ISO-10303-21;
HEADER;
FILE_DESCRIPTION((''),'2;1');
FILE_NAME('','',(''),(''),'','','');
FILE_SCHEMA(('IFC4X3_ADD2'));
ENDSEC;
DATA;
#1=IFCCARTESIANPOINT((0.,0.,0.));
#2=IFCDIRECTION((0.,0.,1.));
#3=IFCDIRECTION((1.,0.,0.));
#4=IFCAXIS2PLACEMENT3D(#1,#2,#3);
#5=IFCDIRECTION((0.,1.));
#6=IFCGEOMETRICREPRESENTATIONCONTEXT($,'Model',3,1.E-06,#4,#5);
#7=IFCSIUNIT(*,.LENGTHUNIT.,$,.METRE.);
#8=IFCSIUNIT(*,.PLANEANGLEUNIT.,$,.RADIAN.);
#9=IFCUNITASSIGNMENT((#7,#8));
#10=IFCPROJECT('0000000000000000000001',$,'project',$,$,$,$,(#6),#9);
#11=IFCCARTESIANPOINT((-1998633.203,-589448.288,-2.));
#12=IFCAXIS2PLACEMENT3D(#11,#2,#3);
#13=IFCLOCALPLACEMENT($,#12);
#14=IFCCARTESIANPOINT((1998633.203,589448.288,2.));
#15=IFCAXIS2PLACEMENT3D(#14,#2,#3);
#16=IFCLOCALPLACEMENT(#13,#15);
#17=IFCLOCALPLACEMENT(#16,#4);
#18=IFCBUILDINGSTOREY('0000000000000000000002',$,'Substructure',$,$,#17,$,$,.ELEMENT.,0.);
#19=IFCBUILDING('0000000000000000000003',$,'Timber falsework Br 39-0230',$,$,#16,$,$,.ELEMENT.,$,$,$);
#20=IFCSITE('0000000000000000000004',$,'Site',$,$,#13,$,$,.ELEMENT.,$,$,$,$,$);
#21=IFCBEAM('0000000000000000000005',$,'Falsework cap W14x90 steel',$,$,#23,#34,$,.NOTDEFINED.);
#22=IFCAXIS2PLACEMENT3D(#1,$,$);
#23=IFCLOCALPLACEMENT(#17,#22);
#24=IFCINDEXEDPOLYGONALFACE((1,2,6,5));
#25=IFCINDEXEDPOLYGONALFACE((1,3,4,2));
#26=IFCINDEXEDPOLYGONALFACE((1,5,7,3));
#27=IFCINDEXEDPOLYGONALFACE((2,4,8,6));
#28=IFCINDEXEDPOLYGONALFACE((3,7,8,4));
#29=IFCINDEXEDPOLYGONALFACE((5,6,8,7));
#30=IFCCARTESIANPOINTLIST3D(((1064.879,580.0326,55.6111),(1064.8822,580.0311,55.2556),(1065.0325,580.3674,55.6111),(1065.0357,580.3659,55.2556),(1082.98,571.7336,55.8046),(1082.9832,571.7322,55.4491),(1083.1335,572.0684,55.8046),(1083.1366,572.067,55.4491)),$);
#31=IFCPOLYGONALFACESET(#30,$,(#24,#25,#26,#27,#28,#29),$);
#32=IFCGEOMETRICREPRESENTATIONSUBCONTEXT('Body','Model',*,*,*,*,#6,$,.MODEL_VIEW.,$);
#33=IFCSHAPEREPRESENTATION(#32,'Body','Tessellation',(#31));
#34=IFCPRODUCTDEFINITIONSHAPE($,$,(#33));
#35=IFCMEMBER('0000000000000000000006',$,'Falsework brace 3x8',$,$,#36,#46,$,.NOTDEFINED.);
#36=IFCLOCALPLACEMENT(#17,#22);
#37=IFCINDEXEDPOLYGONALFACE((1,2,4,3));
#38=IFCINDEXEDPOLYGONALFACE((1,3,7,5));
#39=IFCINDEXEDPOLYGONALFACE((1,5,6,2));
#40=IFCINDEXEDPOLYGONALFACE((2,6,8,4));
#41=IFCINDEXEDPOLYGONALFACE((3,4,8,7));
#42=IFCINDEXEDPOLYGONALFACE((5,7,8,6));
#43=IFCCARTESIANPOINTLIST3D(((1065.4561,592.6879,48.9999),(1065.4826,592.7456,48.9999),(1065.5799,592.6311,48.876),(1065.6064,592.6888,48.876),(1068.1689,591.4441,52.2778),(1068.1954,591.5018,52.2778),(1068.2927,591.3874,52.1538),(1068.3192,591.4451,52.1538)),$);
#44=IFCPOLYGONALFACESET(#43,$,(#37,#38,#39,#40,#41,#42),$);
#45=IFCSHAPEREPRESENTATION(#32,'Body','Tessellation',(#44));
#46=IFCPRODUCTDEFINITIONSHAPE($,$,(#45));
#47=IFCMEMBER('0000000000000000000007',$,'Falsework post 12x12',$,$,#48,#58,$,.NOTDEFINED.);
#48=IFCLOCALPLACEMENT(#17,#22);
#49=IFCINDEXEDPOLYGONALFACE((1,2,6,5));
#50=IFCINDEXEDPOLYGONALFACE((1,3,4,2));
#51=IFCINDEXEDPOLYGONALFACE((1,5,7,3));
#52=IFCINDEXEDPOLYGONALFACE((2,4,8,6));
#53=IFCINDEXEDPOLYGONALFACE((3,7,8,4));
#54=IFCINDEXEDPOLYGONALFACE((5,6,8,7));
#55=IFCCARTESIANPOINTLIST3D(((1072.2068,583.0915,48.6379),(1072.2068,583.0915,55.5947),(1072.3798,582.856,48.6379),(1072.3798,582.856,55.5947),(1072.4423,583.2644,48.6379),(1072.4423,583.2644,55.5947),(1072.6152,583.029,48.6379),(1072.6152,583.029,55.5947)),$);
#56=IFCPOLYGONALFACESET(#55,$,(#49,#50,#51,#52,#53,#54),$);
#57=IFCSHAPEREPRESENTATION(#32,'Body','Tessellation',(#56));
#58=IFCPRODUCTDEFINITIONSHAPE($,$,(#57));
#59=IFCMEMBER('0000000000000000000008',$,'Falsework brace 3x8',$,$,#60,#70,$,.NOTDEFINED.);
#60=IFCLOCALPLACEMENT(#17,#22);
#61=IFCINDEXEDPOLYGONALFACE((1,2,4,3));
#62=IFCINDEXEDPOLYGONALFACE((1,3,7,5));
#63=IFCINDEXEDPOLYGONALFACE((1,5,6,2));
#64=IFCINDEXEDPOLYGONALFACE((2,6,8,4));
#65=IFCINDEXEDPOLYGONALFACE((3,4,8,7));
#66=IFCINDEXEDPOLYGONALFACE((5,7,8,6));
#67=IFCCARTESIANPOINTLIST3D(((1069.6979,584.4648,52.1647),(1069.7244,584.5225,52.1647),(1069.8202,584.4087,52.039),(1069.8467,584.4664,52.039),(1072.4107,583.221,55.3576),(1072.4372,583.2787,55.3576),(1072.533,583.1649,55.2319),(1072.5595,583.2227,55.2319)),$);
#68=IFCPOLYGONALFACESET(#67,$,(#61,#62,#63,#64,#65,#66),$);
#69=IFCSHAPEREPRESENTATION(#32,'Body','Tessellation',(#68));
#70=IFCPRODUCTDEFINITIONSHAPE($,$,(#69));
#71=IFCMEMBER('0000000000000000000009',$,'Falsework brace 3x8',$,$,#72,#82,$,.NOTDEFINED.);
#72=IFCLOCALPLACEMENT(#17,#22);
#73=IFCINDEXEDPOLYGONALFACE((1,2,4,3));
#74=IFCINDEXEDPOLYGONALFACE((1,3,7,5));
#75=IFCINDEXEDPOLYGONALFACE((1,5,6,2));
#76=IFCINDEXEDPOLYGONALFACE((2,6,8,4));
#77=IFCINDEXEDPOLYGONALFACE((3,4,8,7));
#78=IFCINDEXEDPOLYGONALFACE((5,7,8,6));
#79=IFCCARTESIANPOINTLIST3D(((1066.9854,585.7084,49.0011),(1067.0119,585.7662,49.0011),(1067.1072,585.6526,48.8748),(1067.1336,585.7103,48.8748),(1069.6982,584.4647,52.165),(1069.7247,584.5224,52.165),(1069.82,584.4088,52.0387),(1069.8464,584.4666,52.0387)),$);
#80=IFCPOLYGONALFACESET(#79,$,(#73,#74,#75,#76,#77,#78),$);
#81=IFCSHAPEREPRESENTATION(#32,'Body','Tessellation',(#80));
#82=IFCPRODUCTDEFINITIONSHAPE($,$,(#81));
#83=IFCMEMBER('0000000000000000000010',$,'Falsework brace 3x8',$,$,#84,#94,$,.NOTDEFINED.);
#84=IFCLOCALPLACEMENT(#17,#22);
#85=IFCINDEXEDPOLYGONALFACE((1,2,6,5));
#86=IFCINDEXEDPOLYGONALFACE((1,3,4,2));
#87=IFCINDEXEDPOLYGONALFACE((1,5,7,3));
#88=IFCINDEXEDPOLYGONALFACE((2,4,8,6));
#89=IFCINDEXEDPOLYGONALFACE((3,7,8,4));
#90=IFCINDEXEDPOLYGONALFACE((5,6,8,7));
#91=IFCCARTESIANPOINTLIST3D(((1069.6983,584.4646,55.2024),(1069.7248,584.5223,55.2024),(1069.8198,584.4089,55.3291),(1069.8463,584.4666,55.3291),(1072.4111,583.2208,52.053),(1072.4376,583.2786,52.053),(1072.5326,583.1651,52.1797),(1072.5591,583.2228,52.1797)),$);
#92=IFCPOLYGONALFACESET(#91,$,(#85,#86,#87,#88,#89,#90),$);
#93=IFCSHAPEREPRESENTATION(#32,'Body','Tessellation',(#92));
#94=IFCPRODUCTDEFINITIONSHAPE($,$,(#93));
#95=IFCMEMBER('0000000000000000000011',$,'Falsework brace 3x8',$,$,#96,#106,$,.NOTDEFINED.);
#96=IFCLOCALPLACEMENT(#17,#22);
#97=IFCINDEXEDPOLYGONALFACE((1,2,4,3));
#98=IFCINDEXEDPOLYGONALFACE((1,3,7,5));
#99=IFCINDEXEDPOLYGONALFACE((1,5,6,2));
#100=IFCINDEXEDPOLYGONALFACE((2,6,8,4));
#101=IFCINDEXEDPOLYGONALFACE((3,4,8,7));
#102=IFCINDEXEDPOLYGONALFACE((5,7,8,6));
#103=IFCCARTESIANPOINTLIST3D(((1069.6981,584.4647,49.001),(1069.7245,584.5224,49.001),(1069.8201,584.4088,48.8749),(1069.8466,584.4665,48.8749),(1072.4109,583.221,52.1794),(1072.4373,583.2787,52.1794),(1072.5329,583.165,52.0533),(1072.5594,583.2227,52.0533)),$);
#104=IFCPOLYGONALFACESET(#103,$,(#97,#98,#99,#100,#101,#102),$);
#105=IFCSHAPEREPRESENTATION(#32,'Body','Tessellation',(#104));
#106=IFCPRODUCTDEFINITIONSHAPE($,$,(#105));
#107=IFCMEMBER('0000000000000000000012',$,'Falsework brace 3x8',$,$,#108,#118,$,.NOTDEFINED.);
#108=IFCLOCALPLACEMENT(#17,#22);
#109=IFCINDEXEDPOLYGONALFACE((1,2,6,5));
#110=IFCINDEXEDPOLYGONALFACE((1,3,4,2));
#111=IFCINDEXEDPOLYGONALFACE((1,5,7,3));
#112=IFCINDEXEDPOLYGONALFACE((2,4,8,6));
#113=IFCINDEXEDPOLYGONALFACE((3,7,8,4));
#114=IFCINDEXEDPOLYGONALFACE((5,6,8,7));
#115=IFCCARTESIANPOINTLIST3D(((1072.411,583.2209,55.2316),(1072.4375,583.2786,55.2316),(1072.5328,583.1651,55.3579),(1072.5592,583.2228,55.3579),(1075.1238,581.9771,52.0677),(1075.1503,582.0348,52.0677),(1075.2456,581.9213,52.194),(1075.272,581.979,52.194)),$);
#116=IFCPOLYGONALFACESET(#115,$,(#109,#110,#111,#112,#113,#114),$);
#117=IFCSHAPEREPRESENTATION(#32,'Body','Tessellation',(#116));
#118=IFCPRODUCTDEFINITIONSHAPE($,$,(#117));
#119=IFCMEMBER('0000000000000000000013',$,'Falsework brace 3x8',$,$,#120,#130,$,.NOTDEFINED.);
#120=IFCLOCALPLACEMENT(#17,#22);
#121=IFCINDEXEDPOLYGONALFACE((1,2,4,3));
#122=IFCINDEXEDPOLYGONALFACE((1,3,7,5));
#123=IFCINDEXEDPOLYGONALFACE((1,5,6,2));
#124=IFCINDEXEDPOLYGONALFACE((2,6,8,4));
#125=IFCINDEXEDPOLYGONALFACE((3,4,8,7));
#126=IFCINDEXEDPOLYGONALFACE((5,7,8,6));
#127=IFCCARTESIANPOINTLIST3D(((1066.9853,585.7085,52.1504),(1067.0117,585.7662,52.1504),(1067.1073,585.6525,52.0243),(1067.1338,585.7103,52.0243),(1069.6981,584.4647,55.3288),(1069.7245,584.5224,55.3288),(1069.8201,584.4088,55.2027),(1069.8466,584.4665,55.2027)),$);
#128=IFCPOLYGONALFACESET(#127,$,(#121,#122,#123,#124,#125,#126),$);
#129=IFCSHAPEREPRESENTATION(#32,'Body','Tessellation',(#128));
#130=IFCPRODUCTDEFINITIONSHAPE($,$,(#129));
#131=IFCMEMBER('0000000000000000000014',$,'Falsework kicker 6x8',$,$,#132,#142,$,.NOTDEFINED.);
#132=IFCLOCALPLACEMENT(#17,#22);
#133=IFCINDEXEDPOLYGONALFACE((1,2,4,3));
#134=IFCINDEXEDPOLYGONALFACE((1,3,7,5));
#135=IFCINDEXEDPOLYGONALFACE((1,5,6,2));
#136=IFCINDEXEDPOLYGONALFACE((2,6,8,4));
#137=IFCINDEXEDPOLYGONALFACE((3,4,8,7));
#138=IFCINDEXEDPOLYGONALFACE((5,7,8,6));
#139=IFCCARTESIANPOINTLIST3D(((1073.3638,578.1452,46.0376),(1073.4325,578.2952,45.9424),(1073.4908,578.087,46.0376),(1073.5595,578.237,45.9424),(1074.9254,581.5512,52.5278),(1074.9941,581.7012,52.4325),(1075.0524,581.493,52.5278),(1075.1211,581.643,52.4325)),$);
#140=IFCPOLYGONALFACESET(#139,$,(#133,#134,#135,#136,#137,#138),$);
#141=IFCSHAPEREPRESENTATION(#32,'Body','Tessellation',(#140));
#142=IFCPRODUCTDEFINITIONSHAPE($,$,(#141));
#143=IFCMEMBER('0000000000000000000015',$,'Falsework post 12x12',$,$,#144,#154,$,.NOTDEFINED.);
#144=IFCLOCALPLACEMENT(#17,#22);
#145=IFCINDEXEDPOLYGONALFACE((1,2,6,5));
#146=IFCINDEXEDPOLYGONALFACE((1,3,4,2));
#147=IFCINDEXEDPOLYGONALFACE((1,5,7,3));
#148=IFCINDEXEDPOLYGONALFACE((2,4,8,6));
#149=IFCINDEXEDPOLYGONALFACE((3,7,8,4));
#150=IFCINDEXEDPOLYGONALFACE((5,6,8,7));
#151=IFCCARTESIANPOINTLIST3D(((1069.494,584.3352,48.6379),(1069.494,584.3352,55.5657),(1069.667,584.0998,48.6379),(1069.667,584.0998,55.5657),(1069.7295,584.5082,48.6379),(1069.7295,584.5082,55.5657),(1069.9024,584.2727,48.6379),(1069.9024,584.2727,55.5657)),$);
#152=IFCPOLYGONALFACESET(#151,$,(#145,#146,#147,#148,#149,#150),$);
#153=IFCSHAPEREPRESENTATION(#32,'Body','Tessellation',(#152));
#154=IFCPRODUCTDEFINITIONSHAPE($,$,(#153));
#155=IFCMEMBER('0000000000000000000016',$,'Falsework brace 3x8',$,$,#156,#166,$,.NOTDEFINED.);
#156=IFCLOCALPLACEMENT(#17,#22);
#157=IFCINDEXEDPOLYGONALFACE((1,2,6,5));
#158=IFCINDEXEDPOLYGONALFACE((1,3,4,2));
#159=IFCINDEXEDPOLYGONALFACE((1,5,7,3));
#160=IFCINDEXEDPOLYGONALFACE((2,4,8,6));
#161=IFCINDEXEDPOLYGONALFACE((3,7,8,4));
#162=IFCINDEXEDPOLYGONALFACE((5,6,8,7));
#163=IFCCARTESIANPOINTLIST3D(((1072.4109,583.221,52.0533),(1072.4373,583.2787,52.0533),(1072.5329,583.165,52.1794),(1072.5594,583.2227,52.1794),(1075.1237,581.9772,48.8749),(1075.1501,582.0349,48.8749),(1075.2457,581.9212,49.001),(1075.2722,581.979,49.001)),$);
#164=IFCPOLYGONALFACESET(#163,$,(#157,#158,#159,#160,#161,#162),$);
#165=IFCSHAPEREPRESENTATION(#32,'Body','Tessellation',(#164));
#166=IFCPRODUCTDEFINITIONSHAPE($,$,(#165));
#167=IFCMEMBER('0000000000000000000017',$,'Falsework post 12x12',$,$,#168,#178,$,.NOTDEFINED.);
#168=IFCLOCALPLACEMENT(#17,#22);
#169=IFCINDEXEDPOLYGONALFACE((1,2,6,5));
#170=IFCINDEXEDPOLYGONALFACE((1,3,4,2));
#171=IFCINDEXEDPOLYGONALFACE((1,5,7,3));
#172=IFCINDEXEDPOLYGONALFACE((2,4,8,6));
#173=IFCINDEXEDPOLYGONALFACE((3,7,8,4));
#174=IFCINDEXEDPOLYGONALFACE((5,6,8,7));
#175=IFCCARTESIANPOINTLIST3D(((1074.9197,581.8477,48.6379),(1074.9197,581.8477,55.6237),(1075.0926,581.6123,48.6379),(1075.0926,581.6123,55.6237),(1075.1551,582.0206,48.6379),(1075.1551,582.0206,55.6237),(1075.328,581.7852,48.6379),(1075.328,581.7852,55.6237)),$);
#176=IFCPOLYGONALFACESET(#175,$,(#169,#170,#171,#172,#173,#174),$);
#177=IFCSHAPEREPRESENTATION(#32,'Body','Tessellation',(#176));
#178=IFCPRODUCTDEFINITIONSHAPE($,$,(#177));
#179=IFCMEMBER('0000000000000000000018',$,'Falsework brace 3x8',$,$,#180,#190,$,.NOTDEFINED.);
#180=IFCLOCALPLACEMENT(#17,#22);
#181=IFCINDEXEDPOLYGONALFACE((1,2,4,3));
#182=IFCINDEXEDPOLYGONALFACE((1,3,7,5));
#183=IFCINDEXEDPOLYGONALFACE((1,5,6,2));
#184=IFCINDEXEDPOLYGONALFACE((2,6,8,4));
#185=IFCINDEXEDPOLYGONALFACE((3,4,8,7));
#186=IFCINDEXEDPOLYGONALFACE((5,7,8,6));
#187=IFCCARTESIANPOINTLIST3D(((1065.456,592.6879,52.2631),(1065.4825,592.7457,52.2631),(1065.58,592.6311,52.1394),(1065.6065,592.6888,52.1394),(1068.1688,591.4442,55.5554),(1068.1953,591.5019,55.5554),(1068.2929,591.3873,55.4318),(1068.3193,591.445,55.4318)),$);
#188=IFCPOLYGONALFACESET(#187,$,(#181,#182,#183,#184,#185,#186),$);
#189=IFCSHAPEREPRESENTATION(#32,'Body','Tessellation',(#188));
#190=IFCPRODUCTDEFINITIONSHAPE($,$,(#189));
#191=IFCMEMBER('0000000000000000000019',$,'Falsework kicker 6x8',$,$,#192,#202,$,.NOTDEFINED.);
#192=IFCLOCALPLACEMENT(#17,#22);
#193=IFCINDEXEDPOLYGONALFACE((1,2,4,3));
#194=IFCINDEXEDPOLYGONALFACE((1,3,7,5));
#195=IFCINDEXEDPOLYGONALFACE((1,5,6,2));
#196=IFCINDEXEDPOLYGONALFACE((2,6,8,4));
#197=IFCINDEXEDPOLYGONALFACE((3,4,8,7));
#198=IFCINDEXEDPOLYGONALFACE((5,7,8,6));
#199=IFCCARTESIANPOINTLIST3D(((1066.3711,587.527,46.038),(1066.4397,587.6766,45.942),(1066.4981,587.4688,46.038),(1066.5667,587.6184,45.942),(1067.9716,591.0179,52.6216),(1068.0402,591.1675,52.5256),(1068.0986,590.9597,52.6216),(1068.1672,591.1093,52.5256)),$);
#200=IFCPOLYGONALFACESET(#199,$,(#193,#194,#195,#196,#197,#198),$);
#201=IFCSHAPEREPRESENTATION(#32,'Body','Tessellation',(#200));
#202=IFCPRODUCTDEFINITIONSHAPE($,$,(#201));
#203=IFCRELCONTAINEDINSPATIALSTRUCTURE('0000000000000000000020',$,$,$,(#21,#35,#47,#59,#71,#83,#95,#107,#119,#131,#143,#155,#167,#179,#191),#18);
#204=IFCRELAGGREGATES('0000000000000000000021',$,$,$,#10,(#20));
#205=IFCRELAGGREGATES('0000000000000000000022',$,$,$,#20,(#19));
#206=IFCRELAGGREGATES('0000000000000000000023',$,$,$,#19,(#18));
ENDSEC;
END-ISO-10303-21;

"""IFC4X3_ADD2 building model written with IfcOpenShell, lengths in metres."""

from ifc_helpers import new_model, si_unit, direction, frame, frame_2d, origin, origin_with_axes, origin_2d, place, context, subcontext, project, spatial, rectangle, extrude, element, save


model = new_model("IFC4X3_ADD2")

# Units and contexts
model_context = context("Model", 3, precision=1e-06, world=origin_with_axes(), true_north=direction((0.0, 1.0)))
body_context = subcontext(model_context, "Body", "Model", "MODEL_VIEW")
ifc_project = project(units=[si_unit("LENGTHUNIT", "METRE"), si_unit("PLANEANGLEUNIT", "RADIAN")], contexts=[model_context])

# Site, building, storey
site_placement = place(None, frame((-1998633.203, -589448.288, -2.0), z_axis=(0.0, 0.0, 1.0), x_axis=(1.0, 0.0, 0.0)))
site = spatial("IfcSite", under=ifc_project, at=site_placement, Name="Site", CompositionType="ELEMENT")
building_placement = place(site_placement, frame((1998633.203, 589448.288, 2.0), z_axis=(0.0, 0.0, 1.0), x_axis=(1.0, 0.0, 0.0)))
building = spatial("IfcBuilding", under=site, at=building_placement, Name="Timber falsework Br 39-0230", CompositionType="ELEMENT")
storey_placement = place(building_placement, origin_with_axes())
storey = spatial("IfcBuildingStorey", under=building, at=storey_placement, Name="Substructure", CompositionType="ELEMENT", Elevation=0.0)

# Beam
beam_placement = place(storey_placement, frame((1064.9589, 580.1985, 55.2556), z_axis=(0.908971, -0.416746, 0.009717), x_axis=(0.416765, 0.909014, 0.0)))
element("IfcBeam", 1, at=beam_placement, inside=storey, Name="Falsework cap W14x90 steel", PredefinedType="NOTDEFINED", context=body_context, shape_type="SweptSolid", body=[
    extrude(rectangle(XDim=0.3683, YDim=0.3556, at=frame_2d((0.0, 0.1778))), origin(), (0.0, 0.0, 1.0), 19.9137),
])

# Members
member_1_placement = place(storey_placement, frame((1065.5313, 592.6884, 48.9379), z_axis=(0.611973, -0.280578, 0.739436), x_axis=(0.416765, 0.909014, 0.0)))
element("IfcMember", 2, at=member_1_placement, inside=storey, Name="Falsework brace 3x8", PredefinedType="NOTDEFINED", context=body_context, shape_type="SweptSolid", body=[
    extrude(rectangle(XDim=0.0635, YDim=0.1841, at=origin_2d()), origin(), (0.0, 0.0, 1.0), 4.4329),
])
member_2_placement = place(storey_placement, frame((1072.411, 583.0602, 48.6379), z_axis=(0.0, 0.0, 1.0), x_axis=(-0.805928, -0.592013, 0.0)))
element("IfcMember", 3, at=member_2_placement, inside=storey, Name="Falsework post 12x12", PredefinedType="NOTDEFINED", context=body_context, shape_type="SweptSolid", body=[
    extrude(rectangle(XDim=0.2921, YDim=0.2921, at=origin_2d()), origin(), (0.0, 0.0, 1.0), 6.9568),
])
member_3_placement = place(storey_placement, frame((1069.7723, 584.4656, 52.1018), z_axis=(0.620715, -0.284586, 0.730564), x_axis=(0.416765, 0.909014, 0.0)))
element("IfcMember", 4, at=member_3_placement, inside=storey, Name="Falsework brace 3x8", PredefinedType="NOTDEFINED", context=body_context, shape_type="SweptSolid", body=[
    extrude(rectangle(XDim=0.0635, YDim=0.1841, at=origin_2d()), origin(), (0.0, 0.0, 1.0), 4.3705),
])
member_4_placement = place(storey_placement, frame((1067.0595, 585.7094, 48.9379), z_axis=(0.623732, -0.285969, 0.727448), x_axis=(0.416765, 0.909014, 0.0)))
element("IfcMember", 5, at=member_4_placement, inside=storey, Name="Falsework brace 3x8", PredefinedType="NOTDEFINED", context=body_context, shape_type="SweptSolid", body=[
    extrude(rectangle(XDim=0.0635, YDim=0.1841, at=origin_2d()), origin(), (0.0, 0.0, 1.0), 4.3493),
])
member_5_placement = place(storey_placement, frame((1069.7723, 584.4656, 55.2657), z_axis=(0.625247, -0.286663, -0.725872), x_axis=(0.416765, 0.909014, 0.0)))
element("IfcMember", 6, at=member_5_placement, inside=storey, Name="Falsework brace 3x8", PredefinedType="NOTDEFINED", context=body_context, shape_type="SweptSolid", body=[
    extrude(rectangle(XDim=0.0635, YDim=0.1841, at=origin_2d()), origin(), (0.0, 0.0, 1.0), 4.3388),
])
member_6_placement = place(storey_placement, frame((1069.7723, 584.4656, 48.9379), z_axis=(0.622221, -0.285276, 0.729012), x_axis=(0.416765, 0.909014, 0.0)))
element("IfcMember", 7, at=member_6_placement, inside=storey, Name="Falsework brace 3x8", PredefinedType="NOTDEFINED", context=body_context, shape_type="SweptSolid", body=[
    extrude(rectangle(XDim=0.0635, YDim=0.1841, at=origin_2d()), origin(), (0.0, 0.0, 1.0), 4.3599),
])
member_7_placement = place(storey_placement, frame((1072.4851, 583.2218, 55.2947), z_axis=(0.623732, -0.285969, -0.727448), x_axis=(0.416765, 0.909014, 0.0)))
element("IfcMember", 8, at=member_7_placement, inside=storey, Name="Falsework brace 3x8", PredefinedType="NOTDEFINED", context=body_context, shape_type="SweptSolid", body=[
    extrude(rectangle(XDim=0.0635, YDim=0.1841, at=origin_2d()), origin(), (0.0, 0.0, 1.0), 4.3493),
])
member_8_placement = place(storey_placement, frame((1067.0595, 585.7094, 52.0873), z_axis=(0.622221, -0.285276, 0.729012), x_axis=(0.416765, 0.909014, 0.0)))
element("IfcMember", 9, at=member_8_placement, inside=storey, Name="Falsework brace 3x8", PredefinedType="NOTDEFINED", context=body_context, shape_type="SweptSolid", body=[
    extrude(rectangle(XDim=0.0635, YDim=0.1841, at=origin_2d()), origin(), (0.0, 0.0, 1.0), 4.3599),
])
member_9_placement = place(storey_placement, frame((1075.0233, 581.5971, 52.4801), z_axis=(-0.208377, -0.454494, -0.866033), x_axis=(0.909014, -0.416765, 0.0)))
element("IfcMember", 10, at=member_9_placement, inside=storey, Name="Falsework kicker 6x8", PredefinedType="NOTDEFINED", context=body_context, shape_type="SweptSolid", body=[
    extrude(rectangle(XDim=0.1397, YDim=0.1905, at=origin_2d()), origin(), (0.0, 0.0, 1.0), 7.4941),
])
member_10_placement = place(storey_placement, frame((1069.6982, 584.304, 48.6379), z_axis=(0.0, 0.0, 1.0), x_axis=(-0.805928, -0.592013, 0.0)))
element("IfcMember", 11, at=member_10_placement, inside=storey, Name="Falsework post 12x12", PredefinedType="NOTDEFINED", context=body_context, shape_type="SweptSolid", body=[
    extrude(rectangle(XDim=0.2921, YDim=0.2921, at=origin_2d()), origin(), (0.0, 0.0, 1.0), 6.9278),
])
member_11_placement = place(storey_placement, frame((1072.4851, 583.2218, 52.1163), z_axis=(0.622221, -0.285276, -0.729012), x_axis=(0.416765, 0.909014, 0.0)))
element("IfcMember", 12, at=member_11_placement, inside=storey, Name="Falsework brace 3x8", PredefinedType="NOTDEFINED", context=body_context, shape_type="SweptSolid", body=[
    extrude(rectangle(XDim=0.0635, YDim=0.1841, at=origin_2d()), origin(), (0.0, 0.0, 1.0), 4.3599),
])
member_12_placement = place(storey_placement, frame((1075.1238, 581.8164, 48.6379), z_axis=(0.0, 0.0, 1.0), x_axis=(-0.805928, -0.592013, 0.0)))
element("IfcMember", 13, at=member_12_placement, inside=storey, Name="Falsework post 12x12", PredefinedType="NOTDEFINED", context=body_context, shape_type="SweptSolid", body=[
    extrude(rectangle(XDim=0.2921, YDim=0.2921, at=origin_2d()), origin(), (0.0, 0.0, 1.0), 6.9858),
])
member_13_placement = place(storey_placement, frame((1065.5313, 592.6884, 52.2013), z_axis=(0.610495, -0.2799, 0.740913), x_axis=(0.416765, 0.909014, 0.0)))
element("IfcMember", 14, at=member_13_placement, inside=storey, Name="Falsework brace 3x8", PredefinedType="NOTDEFINED", context=body_context, shape_type="SweptSolid", body=[
    extrude(rectangle(XDim=0.0635, YDim=0.1841, at=origin_2d()), origin(), (0.0, 0.0, 1.0), 4.4436),
])
member_14_placement = place(storey_placement, frame((1068.0694, 591.0636, 52.5736), z_axis=(-0.209994, -0.458022, -0.863781), x_axis=(0.909014, -0.416765, 0.0)))
element("IfcMember", 15, at=member_14_placement, inside=storey, Name="Falsework kicker 6x8", PredefinedType="NOTDEFINED", context=body_context, shape_type="SweptSolid", body=[
    extrude(rectangle(XDim=0.1397, YDim=0.1905, at=origin_2d()), origin(), (0.0, 0.0, 1.0), 7.6218),
])

save(model, "model.ifc")
